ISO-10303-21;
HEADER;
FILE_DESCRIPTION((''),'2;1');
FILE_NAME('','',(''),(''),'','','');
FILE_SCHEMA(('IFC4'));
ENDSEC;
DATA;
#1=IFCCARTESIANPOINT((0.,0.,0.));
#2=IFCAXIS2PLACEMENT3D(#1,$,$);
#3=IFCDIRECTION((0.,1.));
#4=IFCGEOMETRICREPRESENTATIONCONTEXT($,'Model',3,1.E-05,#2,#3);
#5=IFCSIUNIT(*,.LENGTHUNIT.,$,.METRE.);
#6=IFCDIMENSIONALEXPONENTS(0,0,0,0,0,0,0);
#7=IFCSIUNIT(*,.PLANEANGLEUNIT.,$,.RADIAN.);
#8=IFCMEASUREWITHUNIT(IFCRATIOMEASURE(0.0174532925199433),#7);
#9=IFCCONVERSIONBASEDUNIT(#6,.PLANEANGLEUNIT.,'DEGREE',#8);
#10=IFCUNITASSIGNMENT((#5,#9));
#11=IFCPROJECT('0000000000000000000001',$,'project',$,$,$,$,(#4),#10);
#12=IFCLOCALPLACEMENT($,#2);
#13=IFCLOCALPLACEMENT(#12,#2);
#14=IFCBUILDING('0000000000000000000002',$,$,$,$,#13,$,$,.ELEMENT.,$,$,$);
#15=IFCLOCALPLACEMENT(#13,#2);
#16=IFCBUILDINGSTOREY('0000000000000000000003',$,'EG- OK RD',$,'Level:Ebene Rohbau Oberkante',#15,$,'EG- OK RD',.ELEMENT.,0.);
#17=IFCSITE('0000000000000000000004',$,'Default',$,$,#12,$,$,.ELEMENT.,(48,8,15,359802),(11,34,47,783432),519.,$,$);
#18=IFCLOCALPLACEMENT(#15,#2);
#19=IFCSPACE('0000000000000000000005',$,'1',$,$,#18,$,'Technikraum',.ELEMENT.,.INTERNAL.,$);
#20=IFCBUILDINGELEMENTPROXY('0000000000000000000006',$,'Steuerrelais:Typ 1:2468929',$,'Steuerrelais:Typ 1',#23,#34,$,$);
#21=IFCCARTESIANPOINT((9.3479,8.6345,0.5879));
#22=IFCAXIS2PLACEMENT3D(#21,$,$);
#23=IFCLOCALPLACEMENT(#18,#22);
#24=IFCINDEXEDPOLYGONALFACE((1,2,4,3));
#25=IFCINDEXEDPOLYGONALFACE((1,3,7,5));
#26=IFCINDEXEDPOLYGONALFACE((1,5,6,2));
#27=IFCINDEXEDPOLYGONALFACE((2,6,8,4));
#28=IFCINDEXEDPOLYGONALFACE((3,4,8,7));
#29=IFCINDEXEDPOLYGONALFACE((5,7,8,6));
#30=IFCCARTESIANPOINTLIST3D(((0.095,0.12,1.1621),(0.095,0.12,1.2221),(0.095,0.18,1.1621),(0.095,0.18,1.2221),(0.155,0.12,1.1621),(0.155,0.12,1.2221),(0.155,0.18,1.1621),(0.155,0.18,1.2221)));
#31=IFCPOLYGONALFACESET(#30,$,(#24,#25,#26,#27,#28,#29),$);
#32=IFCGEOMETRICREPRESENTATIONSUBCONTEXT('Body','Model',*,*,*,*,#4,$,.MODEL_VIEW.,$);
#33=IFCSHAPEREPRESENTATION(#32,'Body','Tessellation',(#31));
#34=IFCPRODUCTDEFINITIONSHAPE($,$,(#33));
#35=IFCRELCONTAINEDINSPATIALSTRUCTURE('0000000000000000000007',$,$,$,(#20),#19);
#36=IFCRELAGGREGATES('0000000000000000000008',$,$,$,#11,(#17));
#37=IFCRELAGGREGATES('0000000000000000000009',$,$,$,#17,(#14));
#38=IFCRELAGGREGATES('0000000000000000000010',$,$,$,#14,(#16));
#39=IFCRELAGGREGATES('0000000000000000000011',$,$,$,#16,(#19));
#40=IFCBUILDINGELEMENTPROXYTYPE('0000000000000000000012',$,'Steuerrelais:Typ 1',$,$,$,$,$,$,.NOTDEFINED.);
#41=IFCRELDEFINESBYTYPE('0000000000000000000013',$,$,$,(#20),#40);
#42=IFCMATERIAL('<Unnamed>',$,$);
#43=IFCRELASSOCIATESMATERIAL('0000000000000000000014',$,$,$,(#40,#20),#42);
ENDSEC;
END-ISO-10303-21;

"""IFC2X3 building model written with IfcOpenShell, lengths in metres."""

from ifc_helpers import new_model, entity, si_unit, converted_unit, direction, frame, origin, origin_2d_with_axis, place, context, subcontext, project, spatial, rectangle, extrude, source, transform, mapped, material, type_object, type_shapes, element, save


model = new_model("IFC2X3")

# Units and contexts
model_context = context("Model", 3, precision=1e-05, world=origin(), true_north=direction((0.0, 1.0)))
body_context = subcontext(model_context, "Body", "Model", "MODEL_VIEW")
ifc_project = project(units=[si_unit("LENGTHUNIT", "METRE"), converted_unit("PLANEANGLEUNIT", "DEGREE", entity("IfcRatioMeasure", 0.0174532925199433), si_unit("PLANEANGLEUNIT", "RADIAN"), dimensions=[0, 0, 0, 0, 0, 0, 0])], contexts=[model_context])

# Site, building, storey
site_placement = place(None, origin())
site = spatial("IfcSite", under=ifc_project, at=site_placement, Name="Default", CompositionType="ELEMENT", RefLatitude=(48, 8, 15, 359802), RefLongitude=(11, 34, 47, 783432), RefElevation=519.0)
building_placement = place(site_placement, origin())
building = spatial("IfcBuilding", under=site, at=building_placement, CompositionType="ELEMENT")
storey_placement = place(building_placement, origin())
storey = spatial("IfcBuildingStorey", under=building, at=storey_placement, Name="EG- OK RD", ObjectType="Level:Ebene Rohbau Oberkante", LongName="EG- OK RD", CompositionType="ELEMENT", Elevation=0.0)

# Shared definitions
space_placement = place(storey_placement, origin())
space = spatial("IfcSpace", under=storey, at=space_placement, Name="1", LongName="Technikraum", CompositionType="ELEMENT", InteriorOrExteriorSpace="INTERNAL")

# Building element proxy
ifc_material_1 = material(Name="<Unnamed>")
building_element_proxy_type_1 = type_object("IfcBuildingElementProxyType", Name="Steuerrelais:Typ 1", PredefinedType="NOTDEFINED", material=ifc_material_1)
shared_shape_1 = source(origin(), body_context, "Body", "SweptSolid", [
    extrude(rectangle(XDim=0.06, YDim=0.06, at=origin_2d_with_axis()), frame((0.125, 0.15, 1.1621), z_axis=(0.0, 0.0, 1.0), x_axis=(0.0, 1.0, 0.0)), (0.0, 0.0, 1.0), 0.06),
])
type_shapes(building_element_proxy_type_1, [shared_shape_1])
proxy_1_placement = place(space_placement, frame((9.3479, 8.6345, 0.5879)))
element("IfcBuildingElementProxy", 1, at=proxy_1_placement, inside=space, type_object=building_element_proxy_type_1, material=ifc_material_1, Name="Steuerrelais:Typ 1:2468929", ObjectType="Steuerrelais:Typ 1", context=body_context, shape_type="MappedRepresentation", body=[
    mapped(shared_shape_1, transform((0.0, 0.0, 0.0), scale=1.0)),
])

save(model, "model.ifc")
